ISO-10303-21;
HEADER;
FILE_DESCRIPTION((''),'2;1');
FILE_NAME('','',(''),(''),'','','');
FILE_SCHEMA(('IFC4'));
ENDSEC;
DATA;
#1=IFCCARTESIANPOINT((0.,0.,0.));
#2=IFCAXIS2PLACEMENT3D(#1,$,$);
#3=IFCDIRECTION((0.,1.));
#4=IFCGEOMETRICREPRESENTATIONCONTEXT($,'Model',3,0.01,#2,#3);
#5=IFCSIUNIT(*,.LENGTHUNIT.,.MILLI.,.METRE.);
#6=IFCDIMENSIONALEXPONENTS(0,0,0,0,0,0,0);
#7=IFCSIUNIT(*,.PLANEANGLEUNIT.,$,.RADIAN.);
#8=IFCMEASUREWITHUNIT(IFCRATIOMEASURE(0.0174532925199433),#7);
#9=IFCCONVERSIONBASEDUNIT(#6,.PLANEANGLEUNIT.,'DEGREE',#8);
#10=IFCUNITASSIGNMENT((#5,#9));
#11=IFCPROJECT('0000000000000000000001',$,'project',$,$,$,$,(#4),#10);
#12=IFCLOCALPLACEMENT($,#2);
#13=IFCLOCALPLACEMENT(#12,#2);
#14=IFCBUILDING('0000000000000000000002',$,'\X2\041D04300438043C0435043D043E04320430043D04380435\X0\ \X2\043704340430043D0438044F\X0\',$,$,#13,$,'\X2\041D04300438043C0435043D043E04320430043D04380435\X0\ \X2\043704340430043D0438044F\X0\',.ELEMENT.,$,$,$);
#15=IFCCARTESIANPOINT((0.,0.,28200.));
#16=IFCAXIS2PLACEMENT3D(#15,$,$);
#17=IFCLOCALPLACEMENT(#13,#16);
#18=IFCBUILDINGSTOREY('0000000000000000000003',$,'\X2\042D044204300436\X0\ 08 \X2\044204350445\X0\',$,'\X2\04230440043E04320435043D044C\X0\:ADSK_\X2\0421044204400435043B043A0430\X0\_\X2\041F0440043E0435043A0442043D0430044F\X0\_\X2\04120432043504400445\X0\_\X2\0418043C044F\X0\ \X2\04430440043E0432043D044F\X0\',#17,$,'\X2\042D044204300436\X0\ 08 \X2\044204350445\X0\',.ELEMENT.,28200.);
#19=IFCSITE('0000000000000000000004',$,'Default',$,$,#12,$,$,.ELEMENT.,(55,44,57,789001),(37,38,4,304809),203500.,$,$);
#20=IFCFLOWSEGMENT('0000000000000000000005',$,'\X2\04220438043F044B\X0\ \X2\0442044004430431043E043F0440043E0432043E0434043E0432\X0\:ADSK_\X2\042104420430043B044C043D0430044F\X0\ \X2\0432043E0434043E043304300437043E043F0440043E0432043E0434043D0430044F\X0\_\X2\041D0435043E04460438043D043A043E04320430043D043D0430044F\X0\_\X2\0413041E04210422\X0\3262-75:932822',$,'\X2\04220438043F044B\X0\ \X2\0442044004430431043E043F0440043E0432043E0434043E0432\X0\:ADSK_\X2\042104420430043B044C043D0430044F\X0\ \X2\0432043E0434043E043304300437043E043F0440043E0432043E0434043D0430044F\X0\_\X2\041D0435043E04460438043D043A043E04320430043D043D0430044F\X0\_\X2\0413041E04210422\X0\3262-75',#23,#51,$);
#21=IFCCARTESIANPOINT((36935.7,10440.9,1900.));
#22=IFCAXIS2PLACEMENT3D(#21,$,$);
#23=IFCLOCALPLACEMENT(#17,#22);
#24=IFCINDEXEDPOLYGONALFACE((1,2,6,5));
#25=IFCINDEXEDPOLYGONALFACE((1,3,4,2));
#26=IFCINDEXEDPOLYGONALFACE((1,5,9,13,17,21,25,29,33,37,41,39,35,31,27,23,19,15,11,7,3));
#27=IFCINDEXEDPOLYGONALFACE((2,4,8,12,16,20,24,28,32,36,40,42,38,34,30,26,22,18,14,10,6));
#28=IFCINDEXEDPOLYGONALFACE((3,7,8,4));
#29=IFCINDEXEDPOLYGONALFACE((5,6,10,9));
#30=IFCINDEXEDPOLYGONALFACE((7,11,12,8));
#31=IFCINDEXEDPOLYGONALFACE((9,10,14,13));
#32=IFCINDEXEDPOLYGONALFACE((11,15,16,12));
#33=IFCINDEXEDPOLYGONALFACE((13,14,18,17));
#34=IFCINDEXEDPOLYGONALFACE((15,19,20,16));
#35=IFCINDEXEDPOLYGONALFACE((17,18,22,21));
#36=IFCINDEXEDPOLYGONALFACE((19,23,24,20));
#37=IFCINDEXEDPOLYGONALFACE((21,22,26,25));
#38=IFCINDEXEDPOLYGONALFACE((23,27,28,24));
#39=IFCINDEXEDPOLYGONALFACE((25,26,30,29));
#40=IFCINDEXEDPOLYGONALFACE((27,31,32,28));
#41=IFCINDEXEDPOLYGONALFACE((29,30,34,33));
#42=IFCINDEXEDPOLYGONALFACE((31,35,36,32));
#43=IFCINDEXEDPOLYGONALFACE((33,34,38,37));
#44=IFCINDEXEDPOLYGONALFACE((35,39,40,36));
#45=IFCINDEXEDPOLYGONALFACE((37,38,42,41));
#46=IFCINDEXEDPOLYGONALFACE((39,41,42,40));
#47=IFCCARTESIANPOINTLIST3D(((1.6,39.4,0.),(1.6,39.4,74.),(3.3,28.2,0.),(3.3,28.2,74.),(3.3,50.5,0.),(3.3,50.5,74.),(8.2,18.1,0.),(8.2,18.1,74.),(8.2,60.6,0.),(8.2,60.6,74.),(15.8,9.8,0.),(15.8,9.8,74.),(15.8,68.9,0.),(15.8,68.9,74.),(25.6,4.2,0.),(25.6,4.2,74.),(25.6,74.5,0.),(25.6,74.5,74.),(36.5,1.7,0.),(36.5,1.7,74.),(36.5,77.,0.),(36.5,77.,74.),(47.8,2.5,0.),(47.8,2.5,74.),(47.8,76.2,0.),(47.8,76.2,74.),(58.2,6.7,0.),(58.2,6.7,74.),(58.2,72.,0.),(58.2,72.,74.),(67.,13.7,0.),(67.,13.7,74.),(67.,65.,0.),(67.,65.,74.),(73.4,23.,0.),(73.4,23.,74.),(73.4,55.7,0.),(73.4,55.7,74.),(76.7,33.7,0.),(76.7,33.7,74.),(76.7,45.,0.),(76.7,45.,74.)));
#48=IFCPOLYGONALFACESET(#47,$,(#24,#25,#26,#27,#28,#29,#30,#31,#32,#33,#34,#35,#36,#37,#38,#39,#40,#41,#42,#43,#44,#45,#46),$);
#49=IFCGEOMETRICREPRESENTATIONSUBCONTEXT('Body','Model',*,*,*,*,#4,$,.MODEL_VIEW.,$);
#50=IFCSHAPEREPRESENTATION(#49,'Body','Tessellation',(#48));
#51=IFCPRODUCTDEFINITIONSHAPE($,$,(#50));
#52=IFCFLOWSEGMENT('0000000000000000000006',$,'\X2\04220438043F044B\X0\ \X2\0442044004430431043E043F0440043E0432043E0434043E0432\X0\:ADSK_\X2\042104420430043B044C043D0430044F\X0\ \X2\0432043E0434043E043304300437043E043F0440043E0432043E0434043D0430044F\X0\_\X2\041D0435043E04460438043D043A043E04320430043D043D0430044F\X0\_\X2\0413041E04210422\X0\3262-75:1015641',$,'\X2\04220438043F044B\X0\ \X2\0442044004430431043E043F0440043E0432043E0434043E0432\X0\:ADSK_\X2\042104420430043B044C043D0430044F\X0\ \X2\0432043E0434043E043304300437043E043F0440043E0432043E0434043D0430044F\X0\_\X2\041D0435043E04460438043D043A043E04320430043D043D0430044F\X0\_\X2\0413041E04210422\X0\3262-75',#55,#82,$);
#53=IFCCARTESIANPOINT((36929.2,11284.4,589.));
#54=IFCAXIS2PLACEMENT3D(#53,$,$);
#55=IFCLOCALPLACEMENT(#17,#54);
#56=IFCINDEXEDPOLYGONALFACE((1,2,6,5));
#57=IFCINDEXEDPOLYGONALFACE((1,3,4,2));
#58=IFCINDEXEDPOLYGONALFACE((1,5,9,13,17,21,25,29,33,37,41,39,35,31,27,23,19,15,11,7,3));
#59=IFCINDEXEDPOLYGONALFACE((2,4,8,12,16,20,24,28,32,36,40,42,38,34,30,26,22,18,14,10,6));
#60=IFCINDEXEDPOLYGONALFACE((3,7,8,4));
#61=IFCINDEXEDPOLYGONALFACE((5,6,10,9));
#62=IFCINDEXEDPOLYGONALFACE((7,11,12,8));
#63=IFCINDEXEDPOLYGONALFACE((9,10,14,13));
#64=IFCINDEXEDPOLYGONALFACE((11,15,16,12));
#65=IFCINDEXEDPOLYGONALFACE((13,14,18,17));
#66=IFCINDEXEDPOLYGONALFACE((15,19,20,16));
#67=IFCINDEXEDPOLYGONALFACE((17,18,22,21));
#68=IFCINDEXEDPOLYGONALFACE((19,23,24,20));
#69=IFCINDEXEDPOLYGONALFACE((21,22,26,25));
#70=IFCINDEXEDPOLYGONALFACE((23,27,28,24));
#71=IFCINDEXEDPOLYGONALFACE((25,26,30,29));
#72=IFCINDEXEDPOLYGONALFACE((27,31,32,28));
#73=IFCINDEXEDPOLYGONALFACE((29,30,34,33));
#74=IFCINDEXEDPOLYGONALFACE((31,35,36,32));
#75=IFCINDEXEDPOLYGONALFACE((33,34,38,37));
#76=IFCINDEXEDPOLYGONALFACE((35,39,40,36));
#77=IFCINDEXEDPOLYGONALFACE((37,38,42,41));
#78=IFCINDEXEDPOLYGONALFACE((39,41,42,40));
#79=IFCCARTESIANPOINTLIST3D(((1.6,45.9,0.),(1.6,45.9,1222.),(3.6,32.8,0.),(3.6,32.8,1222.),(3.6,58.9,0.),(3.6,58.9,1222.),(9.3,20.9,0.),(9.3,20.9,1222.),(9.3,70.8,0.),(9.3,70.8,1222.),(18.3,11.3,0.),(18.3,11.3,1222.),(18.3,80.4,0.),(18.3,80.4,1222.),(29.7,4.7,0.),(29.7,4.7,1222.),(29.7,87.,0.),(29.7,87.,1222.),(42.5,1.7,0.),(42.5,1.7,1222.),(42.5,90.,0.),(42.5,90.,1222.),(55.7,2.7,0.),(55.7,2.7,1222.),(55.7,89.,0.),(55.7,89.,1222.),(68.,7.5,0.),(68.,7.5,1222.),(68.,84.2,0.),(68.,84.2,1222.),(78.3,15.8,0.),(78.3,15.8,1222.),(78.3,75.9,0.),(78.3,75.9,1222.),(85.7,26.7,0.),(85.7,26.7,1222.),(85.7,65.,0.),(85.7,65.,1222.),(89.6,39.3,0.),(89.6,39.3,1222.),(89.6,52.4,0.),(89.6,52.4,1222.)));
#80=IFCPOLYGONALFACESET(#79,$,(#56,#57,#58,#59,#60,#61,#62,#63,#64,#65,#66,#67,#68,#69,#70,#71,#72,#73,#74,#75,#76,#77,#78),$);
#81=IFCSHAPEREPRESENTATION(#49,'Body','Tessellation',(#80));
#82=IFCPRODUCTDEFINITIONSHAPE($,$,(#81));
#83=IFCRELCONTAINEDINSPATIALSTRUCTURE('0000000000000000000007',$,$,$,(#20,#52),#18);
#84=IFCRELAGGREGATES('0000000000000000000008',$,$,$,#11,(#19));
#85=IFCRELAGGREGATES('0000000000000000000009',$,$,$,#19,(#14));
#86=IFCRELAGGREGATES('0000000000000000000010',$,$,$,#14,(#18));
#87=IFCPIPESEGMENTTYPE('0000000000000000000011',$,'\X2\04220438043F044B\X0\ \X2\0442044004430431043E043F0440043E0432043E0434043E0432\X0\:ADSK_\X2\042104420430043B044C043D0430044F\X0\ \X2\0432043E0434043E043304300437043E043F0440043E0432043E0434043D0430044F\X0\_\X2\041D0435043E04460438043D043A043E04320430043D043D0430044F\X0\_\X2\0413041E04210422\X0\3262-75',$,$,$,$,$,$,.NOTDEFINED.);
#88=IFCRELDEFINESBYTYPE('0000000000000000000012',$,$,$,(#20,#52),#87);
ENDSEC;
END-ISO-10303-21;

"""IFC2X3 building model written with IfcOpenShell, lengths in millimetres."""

from ifc_helpers import new_model, entity, si_unit, converted_unit, direction, frame, origin, origin_2d_with_axis, place, context, subcontext, project, spatial, circle, extrude, type_object, element, save


model = new_model("IFC2X3")

# Units and contexts
model_context = context("Model", 3, precision=0.01, world=origin(), true_north=direction((0.0, 1.0)))
body_context = subcontext(model_context, "Body", "Model", "MODEL_VIEW")
ifc_project = project(units=[si_unit("LENGTHUNIT", "METRE", prefix="MILLI"), converted_unit("PLANEANGLEUNIT", "DEGREE", entity("IfcRatioMeasure", 0.0174532925199433), si_unit("PLANEANGLEUNIT", "RADIAN"), dimensions=[0, 0, 0, 0, 0, 0, 0])], contexts=[model_context])

# Site, building, storey
site_placement = place(None, origin())
site = spatial("IfcSite", under=ifc_project, at=site_placement, Name="Default", CompositionType="ELEMENT", RefLatitude=(55, 44, 57, 789001), RefLongitude=(37, 38, 4, 304809), RefElevation=203500.0)
building_placement = place(site_placement, origin())
building = spatial("IfcBuilding", under=site, at=building_placement, Name="Наименование здания", LongName="Наименование здания", CompositionType="ELEMENT")
storey_placement = place(building_placement, frame((0.0, 0.0, 28200.0)))
storey = spatial("IfcBuildingStorey", under=building, at=storey_placement, Name="Этаж 08 тех", ObjectType="Уровень:ADSK_Стрелка_Проектная_Вверх_Имя уровня", LongName="Этаж 08 тех", CompositionType="ELEMENT", Elevation=28200.0)

# Flow segments
pipe_segment_type_1 = type_object("IfcPipeSegmentType", Name="Типы трубопроводов:ADSK_Стальная водогазопроводная_Неоцинкованная_ГОСТ3262-75", PredefinedType="NOTDEFINED")
flow_segment_1_placement = place(storey_placement, frame((36935.7, 10440.9, 1900.0)))
element("IfcFlowSegment", 1, at=flow_segment_1_placement, inside=storey, type_object=pipe_segment_type_1, Name="Типы трубопроводов:ADSK_Стальная водогазопроводная_Неоцинкованная_ГОСТ3262-75:932822", ObjectType="Типы трубопроводов:ADSK_Стальная водогазопроводная_Неоцинкованная_ГОСТ3262-75", context=body_context, shape_type="SweptSolid", body=[
    extrude(circle(Radius=37.8, at=origin_2d_with_axis()), frame((39.4, 39.4, 0.0), z_axis=(0.0, 0.0, 1.0), x_axis=(-1.0, 0.0, 0.0)), (0.0, 0.0, 1.0), 74.0),
])
flow_segment_2_placement = place(storey_placement, frame((36929.2, 11284.4, 589.0)))
element("IfcFlowSegment", 2, at=flow_segment_2_placement, inside=storey, type_object=pipe_segment_type_1, Name="Типы трубопроводов:ADSK_Стальная водогазопроводная_Неоцинкованная_ГОСТ3262-75:1015641", ObjectType="Типы трубопроводов:ADSK_Стальная водогазопроводная_Неоцинкованная_ГОСТ3262-75", context=body_context, shape_type="SweptSolid", body=[
    extrude(circle(Radius=44.2, at=origin_2d_with_axis()), frame((45.9, 45.9, 0.0), z_axis=(0.0, 0.0, 1.0), x_axis=(-1.0, 0.0, 0.0)), (0.0, 0.0, 1.0), 1222.0),
])

save(model, "model.ifc")
